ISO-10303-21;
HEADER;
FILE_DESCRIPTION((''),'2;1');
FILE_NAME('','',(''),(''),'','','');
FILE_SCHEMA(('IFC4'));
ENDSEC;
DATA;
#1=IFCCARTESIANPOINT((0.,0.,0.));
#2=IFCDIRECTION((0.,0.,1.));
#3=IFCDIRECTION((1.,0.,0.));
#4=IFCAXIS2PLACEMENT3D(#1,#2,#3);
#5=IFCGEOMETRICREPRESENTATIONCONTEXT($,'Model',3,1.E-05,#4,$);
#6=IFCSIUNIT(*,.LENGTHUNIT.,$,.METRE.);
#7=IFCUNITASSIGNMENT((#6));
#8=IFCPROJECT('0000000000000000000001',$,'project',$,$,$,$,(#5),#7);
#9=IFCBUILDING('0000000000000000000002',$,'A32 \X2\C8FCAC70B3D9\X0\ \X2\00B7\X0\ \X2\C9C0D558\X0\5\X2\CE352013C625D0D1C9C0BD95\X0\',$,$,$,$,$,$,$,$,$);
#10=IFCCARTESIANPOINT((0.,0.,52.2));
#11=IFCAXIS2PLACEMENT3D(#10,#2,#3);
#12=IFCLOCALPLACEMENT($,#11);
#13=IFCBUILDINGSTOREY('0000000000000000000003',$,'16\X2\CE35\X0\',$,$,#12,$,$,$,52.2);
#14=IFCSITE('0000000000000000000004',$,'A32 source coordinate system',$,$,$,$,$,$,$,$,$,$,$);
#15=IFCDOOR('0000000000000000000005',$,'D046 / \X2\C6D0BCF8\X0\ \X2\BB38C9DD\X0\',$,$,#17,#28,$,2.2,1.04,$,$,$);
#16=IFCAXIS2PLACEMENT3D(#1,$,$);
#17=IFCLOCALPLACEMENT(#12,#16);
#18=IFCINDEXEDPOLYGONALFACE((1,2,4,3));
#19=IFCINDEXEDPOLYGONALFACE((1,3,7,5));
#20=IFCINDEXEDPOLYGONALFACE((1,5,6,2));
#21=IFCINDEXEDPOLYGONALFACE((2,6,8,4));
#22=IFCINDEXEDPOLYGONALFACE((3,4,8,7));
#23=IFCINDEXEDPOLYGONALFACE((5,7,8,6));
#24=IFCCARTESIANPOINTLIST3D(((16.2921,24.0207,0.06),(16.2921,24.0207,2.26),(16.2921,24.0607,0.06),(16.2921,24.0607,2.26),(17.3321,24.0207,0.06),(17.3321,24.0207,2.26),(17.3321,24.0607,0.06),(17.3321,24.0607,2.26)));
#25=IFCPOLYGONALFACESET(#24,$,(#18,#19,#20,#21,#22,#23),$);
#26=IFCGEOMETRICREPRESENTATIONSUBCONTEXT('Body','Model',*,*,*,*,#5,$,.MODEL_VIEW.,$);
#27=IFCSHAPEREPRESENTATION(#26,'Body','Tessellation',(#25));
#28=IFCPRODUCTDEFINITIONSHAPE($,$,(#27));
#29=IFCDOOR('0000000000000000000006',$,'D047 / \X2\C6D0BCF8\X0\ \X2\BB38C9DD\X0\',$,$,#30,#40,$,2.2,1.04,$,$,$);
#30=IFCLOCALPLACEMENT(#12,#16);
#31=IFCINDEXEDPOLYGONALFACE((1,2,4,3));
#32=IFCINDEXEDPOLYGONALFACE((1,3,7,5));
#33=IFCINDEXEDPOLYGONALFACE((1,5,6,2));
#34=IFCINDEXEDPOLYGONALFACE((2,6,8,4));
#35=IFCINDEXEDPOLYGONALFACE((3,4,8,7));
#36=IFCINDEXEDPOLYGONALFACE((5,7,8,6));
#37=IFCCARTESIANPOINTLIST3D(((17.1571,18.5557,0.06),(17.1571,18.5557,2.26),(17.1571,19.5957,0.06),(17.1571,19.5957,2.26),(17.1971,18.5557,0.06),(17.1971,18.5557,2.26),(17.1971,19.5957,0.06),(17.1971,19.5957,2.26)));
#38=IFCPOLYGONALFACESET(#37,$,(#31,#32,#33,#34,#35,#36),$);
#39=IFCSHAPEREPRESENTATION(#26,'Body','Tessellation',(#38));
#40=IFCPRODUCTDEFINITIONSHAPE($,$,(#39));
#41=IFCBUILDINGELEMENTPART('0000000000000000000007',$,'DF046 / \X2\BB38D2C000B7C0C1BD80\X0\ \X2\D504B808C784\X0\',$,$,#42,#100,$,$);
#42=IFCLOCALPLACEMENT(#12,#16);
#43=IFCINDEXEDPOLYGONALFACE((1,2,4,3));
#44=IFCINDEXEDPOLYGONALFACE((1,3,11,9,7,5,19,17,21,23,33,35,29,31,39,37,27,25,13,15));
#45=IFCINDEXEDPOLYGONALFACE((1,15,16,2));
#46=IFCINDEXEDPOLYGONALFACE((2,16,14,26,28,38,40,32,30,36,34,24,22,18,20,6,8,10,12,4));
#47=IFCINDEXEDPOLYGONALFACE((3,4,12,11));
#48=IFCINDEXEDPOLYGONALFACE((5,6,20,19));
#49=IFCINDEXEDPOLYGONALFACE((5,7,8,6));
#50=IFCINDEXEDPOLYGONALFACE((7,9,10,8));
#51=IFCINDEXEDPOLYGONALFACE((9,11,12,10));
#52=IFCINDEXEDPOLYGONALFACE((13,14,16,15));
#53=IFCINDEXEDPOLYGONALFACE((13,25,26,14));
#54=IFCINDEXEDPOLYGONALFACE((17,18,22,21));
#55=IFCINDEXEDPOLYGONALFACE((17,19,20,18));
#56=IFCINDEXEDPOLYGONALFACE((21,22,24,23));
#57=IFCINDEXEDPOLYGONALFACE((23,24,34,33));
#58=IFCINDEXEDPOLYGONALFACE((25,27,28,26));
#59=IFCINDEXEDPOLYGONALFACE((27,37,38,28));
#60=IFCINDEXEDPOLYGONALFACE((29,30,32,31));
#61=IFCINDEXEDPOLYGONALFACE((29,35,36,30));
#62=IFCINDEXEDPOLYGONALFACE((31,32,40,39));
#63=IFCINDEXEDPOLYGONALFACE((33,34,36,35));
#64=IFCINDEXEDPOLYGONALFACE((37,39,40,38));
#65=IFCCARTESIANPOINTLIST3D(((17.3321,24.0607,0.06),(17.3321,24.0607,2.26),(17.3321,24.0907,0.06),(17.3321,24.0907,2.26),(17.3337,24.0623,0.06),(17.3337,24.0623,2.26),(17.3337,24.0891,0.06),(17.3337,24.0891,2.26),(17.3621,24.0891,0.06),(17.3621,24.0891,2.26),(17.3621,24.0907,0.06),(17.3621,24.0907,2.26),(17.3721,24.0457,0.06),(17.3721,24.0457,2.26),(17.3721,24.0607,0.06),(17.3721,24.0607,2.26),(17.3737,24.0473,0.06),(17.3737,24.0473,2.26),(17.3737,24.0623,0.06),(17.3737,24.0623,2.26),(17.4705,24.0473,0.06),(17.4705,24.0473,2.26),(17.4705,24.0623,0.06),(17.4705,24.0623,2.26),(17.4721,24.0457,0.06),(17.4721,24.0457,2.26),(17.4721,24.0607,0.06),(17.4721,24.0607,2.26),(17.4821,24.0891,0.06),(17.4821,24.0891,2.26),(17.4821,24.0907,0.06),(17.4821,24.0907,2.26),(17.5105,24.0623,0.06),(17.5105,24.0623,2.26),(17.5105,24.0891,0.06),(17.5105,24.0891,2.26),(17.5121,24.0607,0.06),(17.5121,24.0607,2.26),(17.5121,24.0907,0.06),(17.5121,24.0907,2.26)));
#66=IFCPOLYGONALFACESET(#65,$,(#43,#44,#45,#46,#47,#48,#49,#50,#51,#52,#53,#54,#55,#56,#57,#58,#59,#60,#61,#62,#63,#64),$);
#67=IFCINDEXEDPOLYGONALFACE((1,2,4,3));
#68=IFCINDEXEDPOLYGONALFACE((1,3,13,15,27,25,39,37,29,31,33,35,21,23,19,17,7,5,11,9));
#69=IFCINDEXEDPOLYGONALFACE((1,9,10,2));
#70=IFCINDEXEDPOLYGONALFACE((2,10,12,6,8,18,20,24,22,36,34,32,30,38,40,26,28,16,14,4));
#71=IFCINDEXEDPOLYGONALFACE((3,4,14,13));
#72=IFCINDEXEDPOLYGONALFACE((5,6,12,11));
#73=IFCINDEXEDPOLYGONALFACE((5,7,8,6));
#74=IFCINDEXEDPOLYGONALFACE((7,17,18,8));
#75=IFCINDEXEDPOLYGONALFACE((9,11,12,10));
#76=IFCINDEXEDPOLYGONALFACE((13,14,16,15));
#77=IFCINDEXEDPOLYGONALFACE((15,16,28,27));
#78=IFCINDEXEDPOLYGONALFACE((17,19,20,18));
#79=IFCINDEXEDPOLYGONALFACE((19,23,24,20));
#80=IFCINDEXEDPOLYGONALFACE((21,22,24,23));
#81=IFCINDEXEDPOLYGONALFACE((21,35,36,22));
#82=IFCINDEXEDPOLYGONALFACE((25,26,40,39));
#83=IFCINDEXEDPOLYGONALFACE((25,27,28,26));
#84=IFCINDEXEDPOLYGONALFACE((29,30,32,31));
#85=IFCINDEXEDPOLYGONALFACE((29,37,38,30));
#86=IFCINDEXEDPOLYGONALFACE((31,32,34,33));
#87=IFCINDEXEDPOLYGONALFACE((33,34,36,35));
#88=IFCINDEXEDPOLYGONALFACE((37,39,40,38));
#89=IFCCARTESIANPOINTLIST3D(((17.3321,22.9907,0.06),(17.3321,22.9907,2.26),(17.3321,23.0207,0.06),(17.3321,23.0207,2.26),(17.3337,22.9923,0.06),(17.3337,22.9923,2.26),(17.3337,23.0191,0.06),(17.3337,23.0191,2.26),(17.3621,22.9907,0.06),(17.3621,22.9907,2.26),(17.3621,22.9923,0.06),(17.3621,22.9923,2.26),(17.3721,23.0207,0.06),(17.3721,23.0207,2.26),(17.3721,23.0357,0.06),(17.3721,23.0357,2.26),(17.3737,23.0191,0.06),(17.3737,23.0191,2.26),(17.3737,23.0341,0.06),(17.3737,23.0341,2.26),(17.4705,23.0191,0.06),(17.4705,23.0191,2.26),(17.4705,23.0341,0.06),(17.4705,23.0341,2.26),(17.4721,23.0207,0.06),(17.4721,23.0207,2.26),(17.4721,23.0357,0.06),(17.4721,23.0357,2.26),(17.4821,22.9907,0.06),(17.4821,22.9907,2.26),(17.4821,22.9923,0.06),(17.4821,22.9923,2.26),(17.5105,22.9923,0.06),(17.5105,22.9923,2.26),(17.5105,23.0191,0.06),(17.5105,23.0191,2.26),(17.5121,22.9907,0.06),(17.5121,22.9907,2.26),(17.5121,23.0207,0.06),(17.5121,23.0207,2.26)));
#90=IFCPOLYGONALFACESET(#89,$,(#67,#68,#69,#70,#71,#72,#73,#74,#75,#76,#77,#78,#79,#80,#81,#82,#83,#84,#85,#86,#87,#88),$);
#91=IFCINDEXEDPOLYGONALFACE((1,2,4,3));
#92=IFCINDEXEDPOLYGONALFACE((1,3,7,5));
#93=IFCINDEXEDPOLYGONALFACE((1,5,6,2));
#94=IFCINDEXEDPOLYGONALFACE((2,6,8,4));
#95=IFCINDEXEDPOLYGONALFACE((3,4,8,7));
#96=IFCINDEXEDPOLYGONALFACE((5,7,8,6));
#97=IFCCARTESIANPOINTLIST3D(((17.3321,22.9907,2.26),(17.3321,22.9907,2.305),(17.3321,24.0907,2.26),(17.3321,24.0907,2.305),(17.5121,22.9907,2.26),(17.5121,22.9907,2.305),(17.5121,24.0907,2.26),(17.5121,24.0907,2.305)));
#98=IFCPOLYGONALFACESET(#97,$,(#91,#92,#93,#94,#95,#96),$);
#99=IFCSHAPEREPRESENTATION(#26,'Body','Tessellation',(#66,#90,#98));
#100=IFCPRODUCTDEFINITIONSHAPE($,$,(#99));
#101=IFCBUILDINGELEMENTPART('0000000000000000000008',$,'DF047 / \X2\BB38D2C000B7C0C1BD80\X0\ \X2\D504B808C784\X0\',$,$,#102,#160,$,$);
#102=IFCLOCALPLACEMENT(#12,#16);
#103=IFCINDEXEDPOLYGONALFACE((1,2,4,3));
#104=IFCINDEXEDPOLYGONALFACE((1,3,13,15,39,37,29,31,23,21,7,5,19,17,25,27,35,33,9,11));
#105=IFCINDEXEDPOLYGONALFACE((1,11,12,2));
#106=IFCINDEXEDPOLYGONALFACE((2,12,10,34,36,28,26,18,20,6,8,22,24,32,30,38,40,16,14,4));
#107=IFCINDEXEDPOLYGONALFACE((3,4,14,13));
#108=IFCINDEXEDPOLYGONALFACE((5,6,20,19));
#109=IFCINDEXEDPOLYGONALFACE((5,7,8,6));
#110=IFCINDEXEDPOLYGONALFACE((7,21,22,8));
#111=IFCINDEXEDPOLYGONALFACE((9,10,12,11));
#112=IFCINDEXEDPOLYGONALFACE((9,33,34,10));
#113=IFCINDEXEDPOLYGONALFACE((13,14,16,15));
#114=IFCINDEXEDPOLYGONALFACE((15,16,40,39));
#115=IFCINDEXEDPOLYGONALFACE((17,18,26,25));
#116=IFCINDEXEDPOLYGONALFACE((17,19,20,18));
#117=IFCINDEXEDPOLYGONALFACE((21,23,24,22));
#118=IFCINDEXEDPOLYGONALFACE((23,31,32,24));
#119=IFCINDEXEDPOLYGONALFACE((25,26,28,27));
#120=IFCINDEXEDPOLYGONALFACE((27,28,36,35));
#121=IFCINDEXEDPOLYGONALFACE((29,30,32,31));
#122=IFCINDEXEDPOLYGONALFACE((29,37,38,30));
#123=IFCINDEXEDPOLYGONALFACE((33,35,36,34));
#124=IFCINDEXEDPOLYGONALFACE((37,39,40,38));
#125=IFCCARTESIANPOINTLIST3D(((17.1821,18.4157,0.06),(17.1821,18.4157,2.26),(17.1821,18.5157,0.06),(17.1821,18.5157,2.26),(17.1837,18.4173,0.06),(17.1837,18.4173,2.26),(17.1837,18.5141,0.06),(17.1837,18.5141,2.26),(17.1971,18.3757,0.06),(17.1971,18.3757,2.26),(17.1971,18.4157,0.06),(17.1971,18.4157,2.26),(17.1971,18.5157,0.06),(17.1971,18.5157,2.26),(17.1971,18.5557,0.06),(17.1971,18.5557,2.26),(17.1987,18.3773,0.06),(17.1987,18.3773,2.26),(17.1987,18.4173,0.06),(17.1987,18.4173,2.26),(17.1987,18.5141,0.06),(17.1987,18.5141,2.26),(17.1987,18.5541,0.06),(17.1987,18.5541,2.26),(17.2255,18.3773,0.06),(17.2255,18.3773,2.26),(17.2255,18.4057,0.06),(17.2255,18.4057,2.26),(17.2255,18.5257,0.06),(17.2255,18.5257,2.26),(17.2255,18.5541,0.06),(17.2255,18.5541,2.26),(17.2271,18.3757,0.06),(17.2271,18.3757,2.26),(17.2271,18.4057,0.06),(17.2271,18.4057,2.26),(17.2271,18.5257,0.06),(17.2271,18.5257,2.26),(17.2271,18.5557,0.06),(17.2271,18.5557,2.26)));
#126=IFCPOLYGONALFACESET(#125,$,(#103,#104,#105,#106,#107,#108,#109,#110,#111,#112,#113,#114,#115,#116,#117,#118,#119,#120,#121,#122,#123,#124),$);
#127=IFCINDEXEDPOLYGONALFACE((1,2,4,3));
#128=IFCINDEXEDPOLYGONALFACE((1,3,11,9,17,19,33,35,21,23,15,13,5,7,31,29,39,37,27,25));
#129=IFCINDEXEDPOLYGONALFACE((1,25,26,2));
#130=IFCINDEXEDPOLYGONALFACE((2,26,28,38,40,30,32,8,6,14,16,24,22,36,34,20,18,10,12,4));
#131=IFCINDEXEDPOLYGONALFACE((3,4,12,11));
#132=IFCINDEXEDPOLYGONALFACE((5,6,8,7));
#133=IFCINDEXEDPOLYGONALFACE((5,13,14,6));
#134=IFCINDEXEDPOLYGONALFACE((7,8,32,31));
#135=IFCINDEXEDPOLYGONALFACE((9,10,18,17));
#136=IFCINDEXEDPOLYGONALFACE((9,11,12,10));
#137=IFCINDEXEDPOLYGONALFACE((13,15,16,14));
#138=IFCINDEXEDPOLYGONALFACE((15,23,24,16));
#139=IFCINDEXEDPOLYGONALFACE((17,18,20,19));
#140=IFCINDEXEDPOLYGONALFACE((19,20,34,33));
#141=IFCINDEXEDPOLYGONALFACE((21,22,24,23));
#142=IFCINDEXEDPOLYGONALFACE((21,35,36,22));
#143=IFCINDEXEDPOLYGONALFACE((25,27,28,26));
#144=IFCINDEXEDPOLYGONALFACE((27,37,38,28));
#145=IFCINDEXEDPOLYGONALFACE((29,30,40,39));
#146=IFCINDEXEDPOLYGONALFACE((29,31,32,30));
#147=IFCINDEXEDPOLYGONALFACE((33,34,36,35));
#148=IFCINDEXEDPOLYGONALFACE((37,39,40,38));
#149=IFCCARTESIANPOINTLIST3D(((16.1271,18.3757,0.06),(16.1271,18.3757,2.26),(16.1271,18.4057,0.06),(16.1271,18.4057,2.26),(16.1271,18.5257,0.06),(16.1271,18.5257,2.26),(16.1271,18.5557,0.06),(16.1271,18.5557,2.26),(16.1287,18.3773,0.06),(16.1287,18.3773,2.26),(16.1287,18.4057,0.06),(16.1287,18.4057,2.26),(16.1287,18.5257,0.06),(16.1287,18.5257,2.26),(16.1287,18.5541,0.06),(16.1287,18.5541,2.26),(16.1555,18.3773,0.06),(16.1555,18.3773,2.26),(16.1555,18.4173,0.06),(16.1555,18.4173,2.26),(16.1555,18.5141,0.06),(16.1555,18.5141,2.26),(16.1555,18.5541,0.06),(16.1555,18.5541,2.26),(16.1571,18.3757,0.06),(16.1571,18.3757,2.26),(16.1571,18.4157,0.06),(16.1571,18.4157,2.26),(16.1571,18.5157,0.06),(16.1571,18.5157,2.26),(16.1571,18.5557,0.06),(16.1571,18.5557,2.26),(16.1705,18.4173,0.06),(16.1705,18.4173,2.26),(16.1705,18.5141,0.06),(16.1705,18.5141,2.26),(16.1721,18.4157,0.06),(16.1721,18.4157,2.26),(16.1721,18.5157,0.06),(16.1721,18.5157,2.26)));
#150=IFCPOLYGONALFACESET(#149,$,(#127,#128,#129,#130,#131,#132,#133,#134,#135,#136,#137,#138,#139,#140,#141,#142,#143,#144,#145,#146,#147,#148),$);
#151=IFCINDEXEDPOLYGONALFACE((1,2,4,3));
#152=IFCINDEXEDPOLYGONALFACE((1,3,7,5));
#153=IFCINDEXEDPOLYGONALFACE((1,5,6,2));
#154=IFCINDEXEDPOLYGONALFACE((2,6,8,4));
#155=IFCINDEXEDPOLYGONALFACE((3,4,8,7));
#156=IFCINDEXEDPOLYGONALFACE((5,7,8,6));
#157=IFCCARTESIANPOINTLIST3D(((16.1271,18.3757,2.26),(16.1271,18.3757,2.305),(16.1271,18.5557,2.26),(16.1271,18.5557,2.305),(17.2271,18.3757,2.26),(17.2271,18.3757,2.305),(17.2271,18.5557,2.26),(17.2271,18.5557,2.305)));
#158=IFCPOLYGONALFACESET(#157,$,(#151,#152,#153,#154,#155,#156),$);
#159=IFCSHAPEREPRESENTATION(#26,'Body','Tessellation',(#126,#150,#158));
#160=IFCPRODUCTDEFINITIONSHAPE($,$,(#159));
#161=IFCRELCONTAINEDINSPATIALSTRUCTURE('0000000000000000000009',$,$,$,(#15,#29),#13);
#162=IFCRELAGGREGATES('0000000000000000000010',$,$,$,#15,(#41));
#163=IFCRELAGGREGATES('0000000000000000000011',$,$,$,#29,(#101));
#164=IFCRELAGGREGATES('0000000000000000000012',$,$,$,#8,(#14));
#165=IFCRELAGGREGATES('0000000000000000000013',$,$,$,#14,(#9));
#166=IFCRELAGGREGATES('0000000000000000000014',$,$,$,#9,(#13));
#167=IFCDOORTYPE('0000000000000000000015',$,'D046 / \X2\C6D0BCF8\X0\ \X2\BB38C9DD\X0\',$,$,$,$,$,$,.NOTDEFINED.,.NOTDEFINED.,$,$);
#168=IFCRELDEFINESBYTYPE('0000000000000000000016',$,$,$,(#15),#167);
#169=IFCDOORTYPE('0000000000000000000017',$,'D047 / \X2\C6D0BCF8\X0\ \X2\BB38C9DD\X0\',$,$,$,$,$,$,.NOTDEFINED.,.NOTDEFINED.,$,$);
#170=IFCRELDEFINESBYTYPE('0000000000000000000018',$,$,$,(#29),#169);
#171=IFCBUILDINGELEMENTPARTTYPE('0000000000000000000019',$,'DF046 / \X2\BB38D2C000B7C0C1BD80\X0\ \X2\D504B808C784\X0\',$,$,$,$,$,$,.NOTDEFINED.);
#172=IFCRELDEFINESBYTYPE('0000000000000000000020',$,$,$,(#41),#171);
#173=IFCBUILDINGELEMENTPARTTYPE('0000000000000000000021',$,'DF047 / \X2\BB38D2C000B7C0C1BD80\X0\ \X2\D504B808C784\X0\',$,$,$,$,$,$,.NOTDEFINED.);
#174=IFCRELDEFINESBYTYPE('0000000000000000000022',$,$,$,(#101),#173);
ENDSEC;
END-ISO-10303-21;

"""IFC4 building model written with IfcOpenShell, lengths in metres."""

from ifc_helpers import new_model, si_unit, frame, origin, origin_with_axes, place, context, subcontext, project, spatial, polyline, outline, extrude, source, transform, mapped, type_object, type_shapes, element, aggregate, save


model = new_model("IFC4")

# Units and contexts
model_context = context("Model", 3, precision=1e-05, world=origin_with_axes())
body_context = subcontext(model_context, "Body", "Model", "MODEL_VIEW")
ifc_project = project(units=[si_unit("LENGTHUNIT", "METRE")], contexts=[model_context])

# Site, building, storey
storey_placement = place(None, frame((0.0, 0.0, 52.2), z_axis=(0.0, 0.0, 1.0), x_axis=(1.0, 0.0, 0.0)))
site = spatial("IfcSite", under=ifc_project, Name="A32 source coordinate system")
building = spatial("IfcBuilding", under=site, Name="A32 주거동 · 지하5층–옥탑지붕")
storey = spatial("IfcBuildingStorey", under=building, at=storey_placement, Name="16층", Elevation=52.2)

# Doors
door_type_1 = type_object("IfcDoorType", Name="D046 / 원본 문짝", OperationType="NOTDEFINED", PredefinedType="NOTDEFINED")
shared_shape_1 = source(origin(), body_context, "Body", "SweptSolid", [
    extrude(outline(polyline([(17.3321, 24.0607), (17.3321, 24.0207), (16.2921, 24.0207), (16.2921, 24.0607), (17.3321, 24.0607)])), frame((0.0, 0.0, 0.06)), (0.0, 0.0, 1.0), 2.2),
])
type_shapes(door_type_1, [shared_shape_1])
door_1_placement = place(storey_placement, origin_with_axes())
door_1 = element("IfcDoor", 1, at=door_1_placement, inside=storey, type_object=door_type_1, Name="D046 / 원본 문짝", OverallHeight=2.2, OverallWidth=1.04, context=body_context, shape_type="MappedRepresentation", body=[
    mapped(shared_shape_1, transform((0.0, 0.0, 0.0), scale=1.0)),
])
door_type_2 = type_object("IfcDoorType", Name="D047 / 원본 문짝", OperationType="NOTDEFINED", PredefinedType="NOTDEFINED")
shared_shape_2 = source(origin(), body_context, "Body", "SweptSolid", [
    extrude(outline(polyline([(17.1971, 18.5557), (17.1571, 18.5557), (17.1571, 19.5957), (17.1971, 19.5957), (17.1971, 18.5557)])), frame((0.0, 0.0, 0.06)), (0.0, 0.0, 1.0), 2.2),
])
type_shapes(door_type_2, [shared_shape_2])
door_2_placement = place(storey_placement, origin_with_axes())
door_2 = element("IfcDoor", 2, at=door_2_placement, inside=storey, type_object=door_type_2, Name="D047 / 원본 문짝", OverallHeight=2.2, OverallWidth=1.04, context=body_context, shape_type="MappedRepresentation", body=[
    mapped(shared_shape_2, transform((0.0, 0.0, 0.0), scale=1.0)),
])

# Building element parts
building_element_part_type_1 = type_object("IfcBuildingElementPartType", Name="DF046 / 문틀·상부 프레임", PredefinedType="NOTDEFINED")
shared_shape_3 = source(origin(), body_context, "Body", "SweptSolid", [
    extrude(outline(polyline([(17.3337, 24.0891), (17.3337, 24.0623), (17.3737, 24.0623), (17.3737, 24.0473), (17.4705, 24.0473), (17.4705, 24.0623), (17.5105, 24.0623), (17.5105, 24.0891), (17.4821, 24.0891), (17.4821, 24.0907), (17.5121, 24.0907), (17.5121, 24.0607), (17.4721, 24.0607), (17.4721, 24.0457), (17.3721, 24.0457), (17.3721, 24.0607), (17.3321, 24.0607), (17.3321, 24.0907), (17.3621, 24.0907), (17.3621, 24.0891), (17.3337, 24.0891)])), frame((0.0, 0.0, 0.06)), (0.0, 0.0, 1.0), 2.2),
    extrude(outline(polyline([(17.3621, 22.9907), (17.3321, 22.9907), (17.3321, 23.0207), (17.3721, 23.0207), (17.3721, 23.0357), (17.4721, 23.0357), (17.4721, 23.0207), (17.5121, 23.0207), (17.5121, 22.9907), (17.4821, 22.9907), (17.4821, 22.9923), (17.5105, 22.9923), (17.5105, 23.0191), (17.4705, 23.0191), (17.4705, 23.0341), (17.3737, 23.0341), (17.3737, 23.0191), (17.3337, 23.0191), (17.3337, 22.9923), (17.3621, 22.9923), (17.3621, 22.9907)])), frame((0.0, 0.0, 0.06)), (0.0, 0.0, 1.0), 2.2),
    extrude(outline(polyline([(17.3321, 22.9907), (17.3321, 24.0907), (17.5121, 24.0907), (17.5121, 22.9907), (17.3321, 22.9907)])), frame((0.0, 0.0, 2.26)), (0.0, 0.0, 1.0), 0.045),
])
type_shapes(building_element_part_type_1, [shared_shape_3])
building_element_part_1_placement = place(door_1_placement, origin_with_axes())
building_element_part_1 = element("IfcBuildingElementPart", 3, at=building_element_part_1_placement, type_object=building_element_part_type_1, Name="DF046 / 문틀·상부 프레임", context=body_context, shape_type="MappedRepresentation", body=[
    mapped(shared_shape_3, transform((0.0, 0.0, 0.0), scale=1.0)),
])
aggregate(door_1, [building_element_part_1])
building_element_part_type_2 = type_object("IfcBuildingElementPartType", Name="DF047 / 문틀·상부 프레임", PredefinedType="NOTDEFINED")
shared_shape_4 = source(origin(), body_context, "Body", "SweptSolid", [
    extrude(outline(polyline([(17.2255, 18.5541), (17.1987, 18.5541), (17.1987, 18.5141), (17.1837, 18.5141), (17.1837, 18.4173), (17.1987, 18.4173), (17.1987, 18.3773), (17.2255, 18.3773), (17.2255, 18.4057), (17.2271, 18.4057), (17.2271, 18.3757), (17.1971, 18.3757), (17.1971, 18.4157), (17.1821, 18.4157), (17.1821, 18.5157), (17.1971, 18.5157), (17.1971, 18.5557), (17.2271, 18.5557), (17.2271, 18.5257), (17.2255, 18.5257), (17.2255, 18.5541)])), frame((0.0, 0.0, 0.06)), (0.0, 0.0, 1.0), 2.2),
    extrude(outline(polyline([(16.1271, 18.5257), (16.1271, 18.5557), (16.1571, 18.5557), (16.1571, 18.5157), (16.1721, 18.5157), (16.1721, 18.4157), (16.1571, 18.4157), (16.1571, 18.3757), (16.1271, 18.3757), (16.1271, 18.4057), (16.1287, 18.4057), (16.1287, 18.3773), (16.1555, 18.3773), (16.1555, 18.4173), (16.1705, 18.4173), (16.1705, 18.5141), (16.1555, 18.5141), (16.1555, 18.5541), (16.1287, 18.5541), (16.1287, 18.5257), (16.1271, 18.5257)])), frame((0.0, 0.0, 0.06)), (0.0, 0.0, 1.0), 2.2),
    extrude(outline(polyline([(16.1271, 18.3757), (16.1271, 18.5557), (17.2271, 18.5557), (17.2271, 18.3757), (16.1271, 18.3757)])), frame((0.0, 0.0, 2.26)), (0.0, 0.0, 1.0), 0.045),
])
type_shapes(building_element_part_type_2, [shared_shape_4])
building_element_part_2_placement = place(door_2_placement, origin_with_axes())
building_element_part_2 = element("IfcBuildingElementPart", 4, at=building_element_part_2_placement, type_object=building_element_part_type_2, Name="DF047 / 문틀·상부 프레임", context=body_context, shape_type="MappedRepresentation", body=[
    mapped(shared_shape_4, transform((0.0, 0.0, 0.0), scale=1.0)),
])
aggregate(door_2, [building_element_part_2])

save(model, "model.ifc")
